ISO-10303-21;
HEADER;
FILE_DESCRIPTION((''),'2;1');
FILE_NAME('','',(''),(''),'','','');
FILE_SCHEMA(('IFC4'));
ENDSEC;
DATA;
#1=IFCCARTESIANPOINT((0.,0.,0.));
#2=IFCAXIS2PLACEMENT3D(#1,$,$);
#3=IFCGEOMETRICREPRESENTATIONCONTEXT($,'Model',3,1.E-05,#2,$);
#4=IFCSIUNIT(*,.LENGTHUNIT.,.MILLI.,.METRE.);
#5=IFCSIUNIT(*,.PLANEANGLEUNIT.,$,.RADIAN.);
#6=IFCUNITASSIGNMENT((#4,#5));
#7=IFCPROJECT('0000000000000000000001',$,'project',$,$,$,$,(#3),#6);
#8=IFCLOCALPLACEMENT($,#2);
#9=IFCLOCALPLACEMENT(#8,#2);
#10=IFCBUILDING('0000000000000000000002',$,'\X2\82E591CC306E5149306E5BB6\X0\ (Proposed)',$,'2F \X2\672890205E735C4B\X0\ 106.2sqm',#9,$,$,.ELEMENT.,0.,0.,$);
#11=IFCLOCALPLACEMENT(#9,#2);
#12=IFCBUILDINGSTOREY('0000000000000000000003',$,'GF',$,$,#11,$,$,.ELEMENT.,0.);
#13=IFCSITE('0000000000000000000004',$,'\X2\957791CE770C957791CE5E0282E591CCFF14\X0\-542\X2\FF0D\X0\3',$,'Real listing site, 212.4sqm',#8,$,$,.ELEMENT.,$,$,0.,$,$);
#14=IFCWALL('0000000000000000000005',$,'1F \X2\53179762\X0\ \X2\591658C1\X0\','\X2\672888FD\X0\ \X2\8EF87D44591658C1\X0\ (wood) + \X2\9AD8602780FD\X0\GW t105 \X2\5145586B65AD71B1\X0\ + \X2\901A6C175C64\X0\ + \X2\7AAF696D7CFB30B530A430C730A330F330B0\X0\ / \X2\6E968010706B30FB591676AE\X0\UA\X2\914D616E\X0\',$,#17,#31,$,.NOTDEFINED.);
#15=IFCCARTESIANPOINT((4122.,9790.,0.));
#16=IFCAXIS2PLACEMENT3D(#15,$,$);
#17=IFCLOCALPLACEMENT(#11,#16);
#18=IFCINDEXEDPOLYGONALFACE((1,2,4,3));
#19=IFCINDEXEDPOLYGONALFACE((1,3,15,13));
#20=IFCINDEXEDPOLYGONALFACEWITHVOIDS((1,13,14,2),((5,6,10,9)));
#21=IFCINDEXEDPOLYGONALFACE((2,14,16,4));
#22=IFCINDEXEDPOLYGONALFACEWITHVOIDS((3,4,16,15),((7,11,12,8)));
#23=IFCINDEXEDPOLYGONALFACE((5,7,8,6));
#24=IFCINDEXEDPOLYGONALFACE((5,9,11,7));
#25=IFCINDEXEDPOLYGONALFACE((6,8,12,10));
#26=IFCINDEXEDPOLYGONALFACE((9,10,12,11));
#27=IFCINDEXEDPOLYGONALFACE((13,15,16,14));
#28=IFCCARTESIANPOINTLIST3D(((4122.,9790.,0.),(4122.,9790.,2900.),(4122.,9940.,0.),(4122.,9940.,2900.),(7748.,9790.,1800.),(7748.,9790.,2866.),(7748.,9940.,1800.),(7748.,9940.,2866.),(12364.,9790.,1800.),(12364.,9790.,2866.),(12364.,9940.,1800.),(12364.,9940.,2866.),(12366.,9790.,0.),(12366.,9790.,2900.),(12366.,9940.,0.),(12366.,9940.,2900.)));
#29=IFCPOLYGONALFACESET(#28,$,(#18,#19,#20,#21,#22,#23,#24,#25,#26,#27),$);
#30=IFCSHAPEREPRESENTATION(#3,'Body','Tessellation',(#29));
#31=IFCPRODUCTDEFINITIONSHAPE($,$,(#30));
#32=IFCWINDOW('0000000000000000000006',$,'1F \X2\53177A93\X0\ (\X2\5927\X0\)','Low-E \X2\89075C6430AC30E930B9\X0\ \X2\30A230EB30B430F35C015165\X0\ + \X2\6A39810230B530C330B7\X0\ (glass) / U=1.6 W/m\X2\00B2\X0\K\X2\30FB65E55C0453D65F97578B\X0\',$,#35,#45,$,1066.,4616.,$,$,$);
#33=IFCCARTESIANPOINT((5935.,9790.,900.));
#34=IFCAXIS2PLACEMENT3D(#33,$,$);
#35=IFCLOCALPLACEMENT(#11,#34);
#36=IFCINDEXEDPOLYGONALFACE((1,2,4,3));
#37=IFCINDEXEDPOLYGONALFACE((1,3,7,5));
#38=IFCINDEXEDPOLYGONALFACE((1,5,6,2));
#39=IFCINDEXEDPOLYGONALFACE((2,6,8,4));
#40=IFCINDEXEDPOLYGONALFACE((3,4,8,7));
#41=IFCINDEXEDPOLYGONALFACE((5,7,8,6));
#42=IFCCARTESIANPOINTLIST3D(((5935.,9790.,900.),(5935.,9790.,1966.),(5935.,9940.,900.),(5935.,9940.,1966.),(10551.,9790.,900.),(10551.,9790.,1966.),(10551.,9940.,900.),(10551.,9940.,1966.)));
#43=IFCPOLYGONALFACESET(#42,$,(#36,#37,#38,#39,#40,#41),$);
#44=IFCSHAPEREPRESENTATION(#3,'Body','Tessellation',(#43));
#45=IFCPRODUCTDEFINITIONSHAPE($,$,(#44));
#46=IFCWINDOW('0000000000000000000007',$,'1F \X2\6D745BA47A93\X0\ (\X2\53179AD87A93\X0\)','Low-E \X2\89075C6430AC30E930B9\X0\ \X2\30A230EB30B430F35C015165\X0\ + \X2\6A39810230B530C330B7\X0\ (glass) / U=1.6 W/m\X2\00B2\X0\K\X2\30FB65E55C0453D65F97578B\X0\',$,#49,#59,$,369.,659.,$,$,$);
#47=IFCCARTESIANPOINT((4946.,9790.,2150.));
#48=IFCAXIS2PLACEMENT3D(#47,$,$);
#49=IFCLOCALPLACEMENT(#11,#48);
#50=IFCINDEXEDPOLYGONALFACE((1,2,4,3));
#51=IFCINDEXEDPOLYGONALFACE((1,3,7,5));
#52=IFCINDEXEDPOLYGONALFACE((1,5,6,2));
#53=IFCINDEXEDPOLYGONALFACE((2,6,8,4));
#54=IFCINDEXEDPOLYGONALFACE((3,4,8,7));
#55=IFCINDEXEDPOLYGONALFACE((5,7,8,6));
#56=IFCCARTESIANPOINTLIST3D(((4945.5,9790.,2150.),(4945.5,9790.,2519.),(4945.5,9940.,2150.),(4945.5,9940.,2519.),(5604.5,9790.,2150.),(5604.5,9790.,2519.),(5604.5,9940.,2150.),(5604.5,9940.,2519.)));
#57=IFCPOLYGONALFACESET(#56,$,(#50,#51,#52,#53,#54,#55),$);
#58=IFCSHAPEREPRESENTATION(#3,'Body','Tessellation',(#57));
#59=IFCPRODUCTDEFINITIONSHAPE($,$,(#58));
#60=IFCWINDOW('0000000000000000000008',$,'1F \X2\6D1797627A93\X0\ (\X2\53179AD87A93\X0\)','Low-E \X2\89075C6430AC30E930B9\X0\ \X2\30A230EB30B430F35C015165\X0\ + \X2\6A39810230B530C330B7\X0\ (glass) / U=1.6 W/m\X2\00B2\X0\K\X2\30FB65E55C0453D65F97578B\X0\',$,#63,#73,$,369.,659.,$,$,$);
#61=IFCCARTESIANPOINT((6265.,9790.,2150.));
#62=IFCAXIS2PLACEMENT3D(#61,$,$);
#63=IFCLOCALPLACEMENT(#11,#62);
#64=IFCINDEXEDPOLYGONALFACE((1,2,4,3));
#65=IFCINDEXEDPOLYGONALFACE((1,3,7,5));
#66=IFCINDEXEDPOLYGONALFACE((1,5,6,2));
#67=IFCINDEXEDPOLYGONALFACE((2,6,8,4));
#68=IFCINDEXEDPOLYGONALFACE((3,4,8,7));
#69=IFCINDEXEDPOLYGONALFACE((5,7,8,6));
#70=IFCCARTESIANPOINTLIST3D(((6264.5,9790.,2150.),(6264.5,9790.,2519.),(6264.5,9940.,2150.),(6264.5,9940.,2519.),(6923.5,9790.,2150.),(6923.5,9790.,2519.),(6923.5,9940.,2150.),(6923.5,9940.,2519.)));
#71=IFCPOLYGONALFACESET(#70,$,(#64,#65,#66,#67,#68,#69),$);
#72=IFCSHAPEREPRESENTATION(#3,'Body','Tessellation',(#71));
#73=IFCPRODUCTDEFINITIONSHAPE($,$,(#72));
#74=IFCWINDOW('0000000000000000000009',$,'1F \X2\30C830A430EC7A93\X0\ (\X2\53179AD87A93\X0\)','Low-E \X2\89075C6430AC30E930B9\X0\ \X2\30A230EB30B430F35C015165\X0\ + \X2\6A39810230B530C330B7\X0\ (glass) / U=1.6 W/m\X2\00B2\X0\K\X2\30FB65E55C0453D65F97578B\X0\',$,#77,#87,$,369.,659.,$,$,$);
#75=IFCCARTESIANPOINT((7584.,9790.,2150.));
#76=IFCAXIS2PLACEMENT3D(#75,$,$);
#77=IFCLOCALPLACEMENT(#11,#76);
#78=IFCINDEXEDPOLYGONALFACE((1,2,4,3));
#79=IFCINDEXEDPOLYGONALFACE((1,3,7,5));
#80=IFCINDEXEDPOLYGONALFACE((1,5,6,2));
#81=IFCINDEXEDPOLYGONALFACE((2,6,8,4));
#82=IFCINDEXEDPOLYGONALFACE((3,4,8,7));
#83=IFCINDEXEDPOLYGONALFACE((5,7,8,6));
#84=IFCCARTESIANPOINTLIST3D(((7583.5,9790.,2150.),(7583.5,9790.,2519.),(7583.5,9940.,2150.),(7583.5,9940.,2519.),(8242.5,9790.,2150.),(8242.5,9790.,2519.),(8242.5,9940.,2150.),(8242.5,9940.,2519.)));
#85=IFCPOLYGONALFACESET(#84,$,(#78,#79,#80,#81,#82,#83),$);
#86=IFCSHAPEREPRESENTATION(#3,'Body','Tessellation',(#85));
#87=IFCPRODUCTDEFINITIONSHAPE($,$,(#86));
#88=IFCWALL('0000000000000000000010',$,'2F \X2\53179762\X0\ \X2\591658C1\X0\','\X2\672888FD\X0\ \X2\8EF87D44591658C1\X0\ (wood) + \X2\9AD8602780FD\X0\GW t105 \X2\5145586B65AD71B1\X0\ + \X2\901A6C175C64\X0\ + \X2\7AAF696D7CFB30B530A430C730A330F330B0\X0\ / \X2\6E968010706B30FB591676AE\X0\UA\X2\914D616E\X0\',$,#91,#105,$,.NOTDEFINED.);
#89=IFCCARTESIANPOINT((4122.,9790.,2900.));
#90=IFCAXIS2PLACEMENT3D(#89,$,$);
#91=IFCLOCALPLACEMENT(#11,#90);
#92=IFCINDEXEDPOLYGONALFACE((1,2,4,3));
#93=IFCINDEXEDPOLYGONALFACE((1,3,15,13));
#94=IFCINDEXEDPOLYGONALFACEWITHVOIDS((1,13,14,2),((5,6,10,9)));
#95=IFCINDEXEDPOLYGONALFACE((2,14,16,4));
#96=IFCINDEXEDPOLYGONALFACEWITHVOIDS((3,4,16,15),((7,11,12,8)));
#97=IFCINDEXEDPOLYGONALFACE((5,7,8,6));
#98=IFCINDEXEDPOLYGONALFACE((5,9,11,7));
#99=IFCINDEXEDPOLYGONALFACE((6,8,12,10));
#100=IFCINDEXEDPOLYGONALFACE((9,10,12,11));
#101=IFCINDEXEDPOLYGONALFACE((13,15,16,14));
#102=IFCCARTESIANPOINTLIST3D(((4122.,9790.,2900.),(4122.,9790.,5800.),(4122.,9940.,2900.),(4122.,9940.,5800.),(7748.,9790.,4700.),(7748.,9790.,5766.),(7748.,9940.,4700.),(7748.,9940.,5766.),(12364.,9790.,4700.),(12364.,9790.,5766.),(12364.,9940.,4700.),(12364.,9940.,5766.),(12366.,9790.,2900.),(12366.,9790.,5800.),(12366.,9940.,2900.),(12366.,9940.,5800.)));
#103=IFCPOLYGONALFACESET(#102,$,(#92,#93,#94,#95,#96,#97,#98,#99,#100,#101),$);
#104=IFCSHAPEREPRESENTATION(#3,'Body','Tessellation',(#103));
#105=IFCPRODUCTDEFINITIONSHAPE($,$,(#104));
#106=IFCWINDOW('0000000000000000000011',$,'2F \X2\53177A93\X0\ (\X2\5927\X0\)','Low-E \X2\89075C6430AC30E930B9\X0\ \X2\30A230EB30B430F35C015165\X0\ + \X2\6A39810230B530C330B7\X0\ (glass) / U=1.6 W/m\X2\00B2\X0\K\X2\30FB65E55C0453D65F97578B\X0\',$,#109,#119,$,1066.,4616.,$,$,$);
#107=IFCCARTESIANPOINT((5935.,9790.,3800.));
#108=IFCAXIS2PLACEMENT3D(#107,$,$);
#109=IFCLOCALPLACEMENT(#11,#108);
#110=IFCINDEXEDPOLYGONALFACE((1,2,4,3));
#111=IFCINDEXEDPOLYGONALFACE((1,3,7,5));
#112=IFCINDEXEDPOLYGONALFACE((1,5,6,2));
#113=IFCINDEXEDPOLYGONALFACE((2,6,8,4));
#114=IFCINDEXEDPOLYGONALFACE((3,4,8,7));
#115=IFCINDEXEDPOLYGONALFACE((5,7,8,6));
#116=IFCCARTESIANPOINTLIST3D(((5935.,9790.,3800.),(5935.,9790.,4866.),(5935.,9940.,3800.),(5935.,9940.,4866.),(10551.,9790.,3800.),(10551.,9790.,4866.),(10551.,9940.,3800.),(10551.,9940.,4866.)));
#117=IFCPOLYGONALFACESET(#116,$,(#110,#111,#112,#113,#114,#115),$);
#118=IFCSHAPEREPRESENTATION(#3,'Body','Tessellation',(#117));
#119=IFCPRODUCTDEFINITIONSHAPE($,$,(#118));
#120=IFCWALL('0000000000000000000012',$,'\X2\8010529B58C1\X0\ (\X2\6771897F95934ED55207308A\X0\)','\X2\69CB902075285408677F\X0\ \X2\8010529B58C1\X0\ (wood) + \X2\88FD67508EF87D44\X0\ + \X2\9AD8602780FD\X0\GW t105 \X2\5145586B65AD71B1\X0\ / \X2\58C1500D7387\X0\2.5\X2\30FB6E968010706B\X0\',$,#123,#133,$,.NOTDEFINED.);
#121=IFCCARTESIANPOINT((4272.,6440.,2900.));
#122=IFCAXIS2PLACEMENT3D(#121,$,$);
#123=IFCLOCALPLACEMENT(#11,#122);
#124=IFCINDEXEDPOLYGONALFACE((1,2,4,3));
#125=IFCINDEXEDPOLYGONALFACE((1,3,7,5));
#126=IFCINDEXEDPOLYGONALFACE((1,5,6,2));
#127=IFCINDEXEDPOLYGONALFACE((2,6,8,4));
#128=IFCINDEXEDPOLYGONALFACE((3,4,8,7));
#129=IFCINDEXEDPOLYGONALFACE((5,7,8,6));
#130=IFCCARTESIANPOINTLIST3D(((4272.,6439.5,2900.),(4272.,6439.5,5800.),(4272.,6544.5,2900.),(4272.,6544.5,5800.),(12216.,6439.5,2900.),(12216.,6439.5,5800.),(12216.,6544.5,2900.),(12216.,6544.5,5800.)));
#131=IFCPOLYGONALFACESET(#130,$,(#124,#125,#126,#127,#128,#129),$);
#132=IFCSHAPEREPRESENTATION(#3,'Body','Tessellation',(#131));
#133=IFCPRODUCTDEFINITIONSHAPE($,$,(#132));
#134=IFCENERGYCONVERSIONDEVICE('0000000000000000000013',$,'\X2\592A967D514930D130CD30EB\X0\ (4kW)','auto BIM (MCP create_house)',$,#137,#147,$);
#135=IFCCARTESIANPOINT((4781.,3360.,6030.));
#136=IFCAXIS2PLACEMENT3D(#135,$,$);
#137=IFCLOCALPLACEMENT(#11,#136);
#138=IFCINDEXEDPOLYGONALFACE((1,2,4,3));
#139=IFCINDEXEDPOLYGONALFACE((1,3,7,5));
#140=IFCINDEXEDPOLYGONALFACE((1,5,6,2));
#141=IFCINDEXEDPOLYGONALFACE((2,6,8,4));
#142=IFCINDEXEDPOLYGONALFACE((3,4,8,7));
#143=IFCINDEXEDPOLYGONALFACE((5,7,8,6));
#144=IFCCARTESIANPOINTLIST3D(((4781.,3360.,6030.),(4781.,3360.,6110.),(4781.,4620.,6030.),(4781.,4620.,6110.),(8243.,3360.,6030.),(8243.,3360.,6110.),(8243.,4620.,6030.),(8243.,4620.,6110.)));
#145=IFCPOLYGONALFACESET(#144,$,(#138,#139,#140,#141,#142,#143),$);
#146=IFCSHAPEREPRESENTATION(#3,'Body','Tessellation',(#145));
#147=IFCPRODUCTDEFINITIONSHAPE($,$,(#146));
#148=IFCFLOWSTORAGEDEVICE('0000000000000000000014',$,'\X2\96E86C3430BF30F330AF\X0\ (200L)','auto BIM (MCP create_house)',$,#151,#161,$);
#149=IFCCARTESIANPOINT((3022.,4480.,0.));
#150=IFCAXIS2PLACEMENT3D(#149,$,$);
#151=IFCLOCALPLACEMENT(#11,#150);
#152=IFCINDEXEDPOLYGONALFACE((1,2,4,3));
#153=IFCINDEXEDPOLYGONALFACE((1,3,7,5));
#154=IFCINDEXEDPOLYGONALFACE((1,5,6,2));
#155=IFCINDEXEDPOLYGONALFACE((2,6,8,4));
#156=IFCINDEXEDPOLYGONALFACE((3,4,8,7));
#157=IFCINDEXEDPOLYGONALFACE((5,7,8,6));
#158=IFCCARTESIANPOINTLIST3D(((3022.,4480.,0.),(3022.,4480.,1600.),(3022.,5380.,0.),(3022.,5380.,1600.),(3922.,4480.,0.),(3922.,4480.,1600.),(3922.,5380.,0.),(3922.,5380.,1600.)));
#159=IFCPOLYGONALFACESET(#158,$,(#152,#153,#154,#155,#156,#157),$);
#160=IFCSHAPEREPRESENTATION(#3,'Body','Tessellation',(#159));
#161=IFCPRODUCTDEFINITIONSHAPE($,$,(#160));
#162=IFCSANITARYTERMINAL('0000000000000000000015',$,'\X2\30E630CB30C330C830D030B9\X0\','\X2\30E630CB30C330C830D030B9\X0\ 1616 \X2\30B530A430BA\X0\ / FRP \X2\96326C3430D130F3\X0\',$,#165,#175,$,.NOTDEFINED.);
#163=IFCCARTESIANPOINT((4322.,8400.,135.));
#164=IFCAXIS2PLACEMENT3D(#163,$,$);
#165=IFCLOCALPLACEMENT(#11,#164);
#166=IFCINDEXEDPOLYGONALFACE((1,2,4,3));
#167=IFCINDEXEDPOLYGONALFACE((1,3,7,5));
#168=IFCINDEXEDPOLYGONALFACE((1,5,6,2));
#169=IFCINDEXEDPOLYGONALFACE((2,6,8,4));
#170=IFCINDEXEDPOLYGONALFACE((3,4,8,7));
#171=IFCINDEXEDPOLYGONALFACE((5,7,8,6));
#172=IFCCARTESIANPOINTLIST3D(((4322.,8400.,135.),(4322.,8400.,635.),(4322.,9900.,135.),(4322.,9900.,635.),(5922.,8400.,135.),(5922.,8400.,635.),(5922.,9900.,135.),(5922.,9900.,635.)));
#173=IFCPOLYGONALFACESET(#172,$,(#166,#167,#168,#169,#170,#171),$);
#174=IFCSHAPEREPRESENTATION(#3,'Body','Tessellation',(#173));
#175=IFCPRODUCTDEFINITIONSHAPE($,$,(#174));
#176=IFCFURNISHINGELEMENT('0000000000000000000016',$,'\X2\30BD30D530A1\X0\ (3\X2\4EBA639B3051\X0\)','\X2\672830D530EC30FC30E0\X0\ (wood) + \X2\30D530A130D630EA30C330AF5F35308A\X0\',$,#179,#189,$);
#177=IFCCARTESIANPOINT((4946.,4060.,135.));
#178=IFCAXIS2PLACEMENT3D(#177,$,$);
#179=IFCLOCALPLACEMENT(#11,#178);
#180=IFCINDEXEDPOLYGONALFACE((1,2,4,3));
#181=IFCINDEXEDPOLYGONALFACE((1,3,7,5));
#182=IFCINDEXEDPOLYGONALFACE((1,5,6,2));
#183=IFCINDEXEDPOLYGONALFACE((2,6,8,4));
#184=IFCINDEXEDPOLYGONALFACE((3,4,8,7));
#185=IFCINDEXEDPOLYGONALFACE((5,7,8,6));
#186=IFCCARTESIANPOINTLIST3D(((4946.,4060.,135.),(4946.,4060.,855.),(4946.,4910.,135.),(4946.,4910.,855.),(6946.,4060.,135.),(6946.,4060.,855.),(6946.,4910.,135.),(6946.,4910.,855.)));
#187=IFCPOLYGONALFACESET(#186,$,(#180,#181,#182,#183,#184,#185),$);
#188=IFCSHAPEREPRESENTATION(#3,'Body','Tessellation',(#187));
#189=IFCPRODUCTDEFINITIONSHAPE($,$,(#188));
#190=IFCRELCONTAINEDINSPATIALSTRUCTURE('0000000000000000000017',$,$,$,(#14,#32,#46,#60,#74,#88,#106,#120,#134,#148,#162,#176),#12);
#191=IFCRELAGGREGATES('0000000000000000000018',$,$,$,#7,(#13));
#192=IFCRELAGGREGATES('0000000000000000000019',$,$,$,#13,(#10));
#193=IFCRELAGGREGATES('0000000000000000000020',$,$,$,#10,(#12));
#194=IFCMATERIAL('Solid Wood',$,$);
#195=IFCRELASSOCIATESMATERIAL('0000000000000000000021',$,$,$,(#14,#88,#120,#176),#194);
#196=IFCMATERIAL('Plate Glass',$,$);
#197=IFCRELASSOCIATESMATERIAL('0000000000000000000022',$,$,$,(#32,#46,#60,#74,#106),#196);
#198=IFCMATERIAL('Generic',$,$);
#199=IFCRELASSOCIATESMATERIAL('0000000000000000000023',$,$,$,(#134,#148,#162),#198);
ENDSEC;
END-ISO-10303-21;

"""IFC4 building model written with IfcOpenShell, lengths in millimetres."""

from ifc_helpers import new_model, si_unit, frame, frame_2d, origin, place, context, project, spatial, rectangle, extrude, material, element, fill, save


model = new_model("IFC4")

# Units and contexts
model_context = context("Model", 3, precision=1e-05, world=origin())
ifc_project = project(units=[si_unit("LENGTHUNIT", "METRE", prefix="MILLI"), si_unit("PLANEANGLEUNIT", "RADIAN")], contexts=[model_context])

# Site, building, storey
site_placement = place(None, origin())
site = spatial("IfcSite", under=ifc_project, at=site_placement, Name="長野県長野市若里４-542－3", ObjectType="Real listing site, 212.4sqm", CompositionType="ELEMENT", RefElevation=0.0)
building_placement = place(site_placement, origin())
building = spatial("IfcBuilding", under=site, at=building_placement, Name="若里の光の家 (Proposed)", ObjectType="2F 木造平屋 106.2sqm", CompositionType="ELEMENT", ElevationOfRefHeight=0.0, ElevationOfTerrain=0.0)
storey_placement = place(building_placement, origin())
storey = spatial("IfcBuildingStorey", under=building, at=storey_placement, Name="GF", CompositionType="ELEMENT", Elevation=0.0)

# Wall, openings, windows
ifc_material_1 = material(Name="Solid Wood")
wall_1_placement = place(storey_placement, frame((4122.0, 9790.0, 0.0)))
wall_1 = element("IfcWall", 1, at=wall_1_placement, inside=storey, material=ifc_material_1, Name="1F 北面 外壁", Description="木製 軸組外壁 (wood) + 高性能GW t105 充填断熱 + 通気層 + 窯業系サイディング / 準耐火・外皮UA配慮", PredefinedType="NOTDEFINED", context=model_context, shape_type="SweptSolid", body=[
    extrude(rectangle(XDim=8244.0, YDim=150.0, at=frame_2d((4122.0, 75.0))), frame((4122.0, 9790.0, 0.0)), (0.0, 0.0, 1.0), 2900.0),
])
opening_1_placement = place(storey_placement, frame((5935.0, 9790.0, 900.0)))
opening_1 = element("IfcOpeningElement", 2, at=opening_1_placement, cuts=wall_1, PredefinedType="NOTDEFINED", context=model_context, shape_type="SweptSolid", body=[
    extrude(rectangle(XDim=4616.0, YDim=150.0, at=frame_2d((2308.0, 75.0))), frame((5935.0, 9790.0, 900.0)), (0.0, 0.0, 1.0), 1066.0),
])
opening_2_placement = place(storey_placement, frame((4946.0, 9790.0, 2150.0)))
opening_2 = element("IfcOpeningElement", 3, at=opening_2_placement, cuts=wall_1, PredefinedType="NOTDEFINED", context=model_context, shape_type="SweptSolid", body=[
    extrude(rectangle(XDim=659.0, YDim=150.0, at=frame_2d((329.0, 75.0))), frame((4946.0, 9790.0, 2150.0)), (0.0, 0.0, 1.0), 369.0),
])
opening_3_placement = place(storey_placement, frame((6265.0, 9790.0, 2150.0)))
opening_3 = element("IfcOpeningElement", 4, at=opening_3_placement, cuts=wall_1, PredefinedType="NOTDEFINED", context=model_context, shape_type="SweptSolid", body=[
    extrude(rectangle(XDim=659.0, YDim=150.0, at=frame_2d((329.0, 75.0))), frame((6265.0, 9790.0, 2150.0)), (0.0, 0.0, 1.0), 369.0),
])
opening_4_placement = place(storey_placement, frame((7584.0, 9790.0, 2150.0)))
opening_4 = element("IfcOpeningElement", 5, at=opening_4_placement, cuts=wall_1, PredefinedType="NOTDEFINED", context=model_context, shape_type="SweptSolid", body=[
    extrude(rectangle(XDim=659.0, YDim=150.0, at=frame_2d((329.0, 75.0))), frame((7584.0, 9790.0, 2150.0)), (0.0, 0.0, 1.0), 369.0),
])
ifc_material_2 = material(Name="Plate Glass")
window_1_placement = place(storey_placement, frame((5935.0, 9790.0, 900.0)))
window_1 = element("IfcWindow", 6, at=window_1_placement, inside=storey, material=ifc_material_2, Name="1F 北窓 (大)", Description="Low-E 複層ガラス アルゴン封入 + 樹脂サッシ (glass) / U=1.6 W/m²K・日射取得型", OverallHeight=1066.0, OverallWidth=4616.0, context=model_context, shape_type="SweptSolid", body=[
    extrude(rectangle(XDim=4616.0, YDim=150.0, at=frame_2d((2308.0, 75.0))), frame((5935.0, 9790.0, 900.0)), (0.0, 0.0, 1.0), 1066.0),
])
fill(opening_1, window_1)
window_2_placement = place(storey_placement, frame((4946.0, 9790.0, 2150.0)))
window_2 = element("IfcWindow", 7, at=window_2_placement, inside=storey, material=ifc_material_2, Name="1F 浴室窓 (北高窓)", Description="Low-E 複層ガラス アルゴン封入 + 樹脂サッシ (glass) / U=1.6 W/m²K・日射取得型", OverallHeight=369.0, OverallWidth=659.0, context=model_context, shape_type="SweptSolid", body=[
    extrude(rectangle(XDim=659.0, YDim=150.0, at=frame_2d((329.0, 75.0))), frame((4946.0, 9790.0, 2150.0)), (0.0, 0.0, 1.0), 369.0),
])
fill(opening_2, window_2)
window_3_placement = place(storey_placement, frame((6265.0, 9790.0, 2150.0)))
window_3 = element("IfcWindow", 8, at=window_3_placement, inside=storey, material=ifc_material_2, Name="1F 洗面窓 (北高窓)", Description="Low-E 複層ガラス アルゴン封入 + 樹脂サッシ (glass) / U=1.6 W/m²K・日射取得型", OverallHeight=369.0, OverallWidth=659.0, context=model_context, shape_type="SweptSolid", body=[
    extrude(rectangle(XDim=659.0, YDim=150.0, at=frame_2d((329.0, 75.0))), frame((6265.0, 9790.0, 2150.0)), (0.0, 0.0, 1.0), 369.0),
])
fill(opening_3, window_3)
window_4_placement = place(storey_placement, frame((7584.0, 9790.0, 2150.0)))
window_4 = element("IfcWindow", 9, at=window_4_placement, inside=storey, material=ifc_material_2, Name="1F トイレ窓 (北高窓)", Description="Low-E 複層ガラス アルゴン封入 + 樹脂サッシ (glass) / U=1.6 W/m²K・日射取得型", OverallHeight=369.0, OverallWidth=659.0, context=model_context, shape_type="SweptSolid", body=[
    extrude(rectangle(XDim=659.0, YDim=150.0, at=frame_2d((329.0, 75.0))), frame((7584.0, 9790.0, 2150.0)), (0.0, 0.0, 1.0), 369.0),
])
fill(opening_4, window_4)

# Wall, opening, window
wall_2_placement = place(storey_placement, frame((4122.0, 9790.0, 2900.0)))
wall_2 = element("IfcWall", 10, at=wall_2_placement, inside=storey, material=ifc_material_1, Name="2F 北面 外壁", Description="木製 軸組外壁 (wood) + 高性能GW t105 充填断熱 + 通気層 + 窯業系サイディング / 準耐火・外皮UA配慮", PredefinedType="NOTDEFINED", context=model_context, shape_type="SweptSolid", body=[
    extrude(rectangle(XDim=8244.0, YDim=150.0, at=frame_2d((4122.0, 75.0))), frame((4122.0, 9790.0, 2900.0)), (0.0, 0.0, 1.0), 2900.0),
])
opening_5_placement = place(storey_placement, frame((5935.0, 9790.0, 3800.0)))
opening_5 = element("IfcOpeningElement", 11, at=opening_5_placement, cuts=wall_2, PredefinedType="NOTDEFINED", context=model_context, shape_type="SweptSolid", body=[
    extrude(rectangle(XDim=4616.0, YDim=150.0, at=frame_2d((2308.0, 75.0))), frame((5935.0, 9790.0, 3800.0)), (0.0, 0.0, 1.0), 1066.0),
])
window_5_placement = place(storey_placement, frame((5935.0, 9790.0, 3800.0)))
window_5 = element("IfcWindow", 12, at=window_5_placement, inside=storey, material=ifc_material_2, Name="2F 北窓 (大)", Description="Low-E 複層ガラス アルゴン封入 + 樹脂サッシ (glass) / U=1.6 W/m²K・日射取得型", OverallHeight=1066.0, OverallWidth=4616.0, context=model_context, shape_type="SweptSolid", body=[
    extrude(rectangle(XDim=4616.0, YDim=150.0, at=frame_2d((2308.0, 75.0))), frame((5935.0, 9790.0, 3800.0)), (0.0, 0.0, 1.0), 1066.0),
])
fill(opening_5, window_5)

# Wall
wall_3_placement = place(storey_placement, frame((4272.0, 6440.0, 2900.0)))
element("IfcWall", 13, at=wall_3_placement, inside=storey, material=ifc_material_1, Name="耐力壁 (東西間仕切り)", Description="構造用合板 耐力壁 (wood) + 製材軸組 + 高性能GW t105 充填断熱 / 壁倍率2.5・準耐火", PredefinedType="NOTDEFINED", context=model_context, shape_type="SweptSolid", body=[
    extrude(rectangle(XDim=7944.0, YDim=105.0, at=frame_2d((3972.0, 52.0))), frame((4272.0, 6440.0, 2900.0)), (0.0, 0.0, 1.0), 2900.0),
])

# Energy conversion device
ifc_material_3 = material(Name="Generic")
energy_conversion_device_placement = place(storey_placement, frame((4781.0, 3360.0, 6030.0)))
element("IfcEnergyConversionDevice", 14, at=energy_conversion_device_placement, inside=storey, material=ifc_material_3, Name="太陽光パネル (4kW)", Description="auto BIM (MCP create_house)", context=model_context, shape_type="SweptSolid", body=[
    extrude(rectangle(XDim=3462.0, YDim=1260.0, at=frame_2d((1731.0, 630.0))), frame((4781.0, 3360.0, 6030.0)), (0.0, 0.0, 1.0), 80.0),
])

# Flow storage device
flow_storage_device_placement = place(storey_placement, frame((3022.0, 4480.0, 0.0)))
element("IfcFlowStorageDevice", 15, at=flow_storage_device_placement, inside=storey, material=ifc_material_3, Name="雨水タンク (200L)", Description="auto BIM (MCP create_house)", context=model_context, shape_type="SweptSolid", body=[
    extrude(rectangle(XDim=900.0, YDim=900.0, at=frame_2d((450.0, 450.0))), frame((3022.0, 4480.0, 0.0)), (0.0, 0.0, 1.0), 1600.0),
])

# Sanitary terminal
sanitary_terminal_placement = place(storey_placement, frame((4322.0, 8400.0, 135.0)))
element("IfcSanitaryTerminal", 16, at=sanitary_terminal_placement, inside=storey, material=ifc_material_3, Name="ユニットバス", Description="ユニットバス 1616 サイズ / FRP 防水パン", PredefinedType="NOTDEFINED", context=model_context, shape_type="SweptSolid", body=[
    extrude(rectangle(XDim=1600.0, YDim=1500.0, at=frame_2d((800.0, 750.0))), frame((4322.0, 8400.0, 135.0)), (0.0, 0.0, 1.0), 500.0),
])

# Furnishing element
furnishing_1_placement = place(storey_placement, frame((4946.0, 4060.0, 135.0)))
element("IfcFurnishingElement", 17, at=furnishing_1_placement, inside=storey, material=ifc_material_1, Name="ソファ (3人掛け)", Description="木フレーム (wood) + ファブリック張り", context=model_context, shape_type="SweptSolid", body=[
    extrude(rectangle(XDim=2000.0, YDim=850.0, at=frame_2d((1000.0, 425.0))), frame((4946.0, 4060.0, 135.0)), (0.0, 0.0, 1.0), 720.0),
])

save(model, "model.ifc")
